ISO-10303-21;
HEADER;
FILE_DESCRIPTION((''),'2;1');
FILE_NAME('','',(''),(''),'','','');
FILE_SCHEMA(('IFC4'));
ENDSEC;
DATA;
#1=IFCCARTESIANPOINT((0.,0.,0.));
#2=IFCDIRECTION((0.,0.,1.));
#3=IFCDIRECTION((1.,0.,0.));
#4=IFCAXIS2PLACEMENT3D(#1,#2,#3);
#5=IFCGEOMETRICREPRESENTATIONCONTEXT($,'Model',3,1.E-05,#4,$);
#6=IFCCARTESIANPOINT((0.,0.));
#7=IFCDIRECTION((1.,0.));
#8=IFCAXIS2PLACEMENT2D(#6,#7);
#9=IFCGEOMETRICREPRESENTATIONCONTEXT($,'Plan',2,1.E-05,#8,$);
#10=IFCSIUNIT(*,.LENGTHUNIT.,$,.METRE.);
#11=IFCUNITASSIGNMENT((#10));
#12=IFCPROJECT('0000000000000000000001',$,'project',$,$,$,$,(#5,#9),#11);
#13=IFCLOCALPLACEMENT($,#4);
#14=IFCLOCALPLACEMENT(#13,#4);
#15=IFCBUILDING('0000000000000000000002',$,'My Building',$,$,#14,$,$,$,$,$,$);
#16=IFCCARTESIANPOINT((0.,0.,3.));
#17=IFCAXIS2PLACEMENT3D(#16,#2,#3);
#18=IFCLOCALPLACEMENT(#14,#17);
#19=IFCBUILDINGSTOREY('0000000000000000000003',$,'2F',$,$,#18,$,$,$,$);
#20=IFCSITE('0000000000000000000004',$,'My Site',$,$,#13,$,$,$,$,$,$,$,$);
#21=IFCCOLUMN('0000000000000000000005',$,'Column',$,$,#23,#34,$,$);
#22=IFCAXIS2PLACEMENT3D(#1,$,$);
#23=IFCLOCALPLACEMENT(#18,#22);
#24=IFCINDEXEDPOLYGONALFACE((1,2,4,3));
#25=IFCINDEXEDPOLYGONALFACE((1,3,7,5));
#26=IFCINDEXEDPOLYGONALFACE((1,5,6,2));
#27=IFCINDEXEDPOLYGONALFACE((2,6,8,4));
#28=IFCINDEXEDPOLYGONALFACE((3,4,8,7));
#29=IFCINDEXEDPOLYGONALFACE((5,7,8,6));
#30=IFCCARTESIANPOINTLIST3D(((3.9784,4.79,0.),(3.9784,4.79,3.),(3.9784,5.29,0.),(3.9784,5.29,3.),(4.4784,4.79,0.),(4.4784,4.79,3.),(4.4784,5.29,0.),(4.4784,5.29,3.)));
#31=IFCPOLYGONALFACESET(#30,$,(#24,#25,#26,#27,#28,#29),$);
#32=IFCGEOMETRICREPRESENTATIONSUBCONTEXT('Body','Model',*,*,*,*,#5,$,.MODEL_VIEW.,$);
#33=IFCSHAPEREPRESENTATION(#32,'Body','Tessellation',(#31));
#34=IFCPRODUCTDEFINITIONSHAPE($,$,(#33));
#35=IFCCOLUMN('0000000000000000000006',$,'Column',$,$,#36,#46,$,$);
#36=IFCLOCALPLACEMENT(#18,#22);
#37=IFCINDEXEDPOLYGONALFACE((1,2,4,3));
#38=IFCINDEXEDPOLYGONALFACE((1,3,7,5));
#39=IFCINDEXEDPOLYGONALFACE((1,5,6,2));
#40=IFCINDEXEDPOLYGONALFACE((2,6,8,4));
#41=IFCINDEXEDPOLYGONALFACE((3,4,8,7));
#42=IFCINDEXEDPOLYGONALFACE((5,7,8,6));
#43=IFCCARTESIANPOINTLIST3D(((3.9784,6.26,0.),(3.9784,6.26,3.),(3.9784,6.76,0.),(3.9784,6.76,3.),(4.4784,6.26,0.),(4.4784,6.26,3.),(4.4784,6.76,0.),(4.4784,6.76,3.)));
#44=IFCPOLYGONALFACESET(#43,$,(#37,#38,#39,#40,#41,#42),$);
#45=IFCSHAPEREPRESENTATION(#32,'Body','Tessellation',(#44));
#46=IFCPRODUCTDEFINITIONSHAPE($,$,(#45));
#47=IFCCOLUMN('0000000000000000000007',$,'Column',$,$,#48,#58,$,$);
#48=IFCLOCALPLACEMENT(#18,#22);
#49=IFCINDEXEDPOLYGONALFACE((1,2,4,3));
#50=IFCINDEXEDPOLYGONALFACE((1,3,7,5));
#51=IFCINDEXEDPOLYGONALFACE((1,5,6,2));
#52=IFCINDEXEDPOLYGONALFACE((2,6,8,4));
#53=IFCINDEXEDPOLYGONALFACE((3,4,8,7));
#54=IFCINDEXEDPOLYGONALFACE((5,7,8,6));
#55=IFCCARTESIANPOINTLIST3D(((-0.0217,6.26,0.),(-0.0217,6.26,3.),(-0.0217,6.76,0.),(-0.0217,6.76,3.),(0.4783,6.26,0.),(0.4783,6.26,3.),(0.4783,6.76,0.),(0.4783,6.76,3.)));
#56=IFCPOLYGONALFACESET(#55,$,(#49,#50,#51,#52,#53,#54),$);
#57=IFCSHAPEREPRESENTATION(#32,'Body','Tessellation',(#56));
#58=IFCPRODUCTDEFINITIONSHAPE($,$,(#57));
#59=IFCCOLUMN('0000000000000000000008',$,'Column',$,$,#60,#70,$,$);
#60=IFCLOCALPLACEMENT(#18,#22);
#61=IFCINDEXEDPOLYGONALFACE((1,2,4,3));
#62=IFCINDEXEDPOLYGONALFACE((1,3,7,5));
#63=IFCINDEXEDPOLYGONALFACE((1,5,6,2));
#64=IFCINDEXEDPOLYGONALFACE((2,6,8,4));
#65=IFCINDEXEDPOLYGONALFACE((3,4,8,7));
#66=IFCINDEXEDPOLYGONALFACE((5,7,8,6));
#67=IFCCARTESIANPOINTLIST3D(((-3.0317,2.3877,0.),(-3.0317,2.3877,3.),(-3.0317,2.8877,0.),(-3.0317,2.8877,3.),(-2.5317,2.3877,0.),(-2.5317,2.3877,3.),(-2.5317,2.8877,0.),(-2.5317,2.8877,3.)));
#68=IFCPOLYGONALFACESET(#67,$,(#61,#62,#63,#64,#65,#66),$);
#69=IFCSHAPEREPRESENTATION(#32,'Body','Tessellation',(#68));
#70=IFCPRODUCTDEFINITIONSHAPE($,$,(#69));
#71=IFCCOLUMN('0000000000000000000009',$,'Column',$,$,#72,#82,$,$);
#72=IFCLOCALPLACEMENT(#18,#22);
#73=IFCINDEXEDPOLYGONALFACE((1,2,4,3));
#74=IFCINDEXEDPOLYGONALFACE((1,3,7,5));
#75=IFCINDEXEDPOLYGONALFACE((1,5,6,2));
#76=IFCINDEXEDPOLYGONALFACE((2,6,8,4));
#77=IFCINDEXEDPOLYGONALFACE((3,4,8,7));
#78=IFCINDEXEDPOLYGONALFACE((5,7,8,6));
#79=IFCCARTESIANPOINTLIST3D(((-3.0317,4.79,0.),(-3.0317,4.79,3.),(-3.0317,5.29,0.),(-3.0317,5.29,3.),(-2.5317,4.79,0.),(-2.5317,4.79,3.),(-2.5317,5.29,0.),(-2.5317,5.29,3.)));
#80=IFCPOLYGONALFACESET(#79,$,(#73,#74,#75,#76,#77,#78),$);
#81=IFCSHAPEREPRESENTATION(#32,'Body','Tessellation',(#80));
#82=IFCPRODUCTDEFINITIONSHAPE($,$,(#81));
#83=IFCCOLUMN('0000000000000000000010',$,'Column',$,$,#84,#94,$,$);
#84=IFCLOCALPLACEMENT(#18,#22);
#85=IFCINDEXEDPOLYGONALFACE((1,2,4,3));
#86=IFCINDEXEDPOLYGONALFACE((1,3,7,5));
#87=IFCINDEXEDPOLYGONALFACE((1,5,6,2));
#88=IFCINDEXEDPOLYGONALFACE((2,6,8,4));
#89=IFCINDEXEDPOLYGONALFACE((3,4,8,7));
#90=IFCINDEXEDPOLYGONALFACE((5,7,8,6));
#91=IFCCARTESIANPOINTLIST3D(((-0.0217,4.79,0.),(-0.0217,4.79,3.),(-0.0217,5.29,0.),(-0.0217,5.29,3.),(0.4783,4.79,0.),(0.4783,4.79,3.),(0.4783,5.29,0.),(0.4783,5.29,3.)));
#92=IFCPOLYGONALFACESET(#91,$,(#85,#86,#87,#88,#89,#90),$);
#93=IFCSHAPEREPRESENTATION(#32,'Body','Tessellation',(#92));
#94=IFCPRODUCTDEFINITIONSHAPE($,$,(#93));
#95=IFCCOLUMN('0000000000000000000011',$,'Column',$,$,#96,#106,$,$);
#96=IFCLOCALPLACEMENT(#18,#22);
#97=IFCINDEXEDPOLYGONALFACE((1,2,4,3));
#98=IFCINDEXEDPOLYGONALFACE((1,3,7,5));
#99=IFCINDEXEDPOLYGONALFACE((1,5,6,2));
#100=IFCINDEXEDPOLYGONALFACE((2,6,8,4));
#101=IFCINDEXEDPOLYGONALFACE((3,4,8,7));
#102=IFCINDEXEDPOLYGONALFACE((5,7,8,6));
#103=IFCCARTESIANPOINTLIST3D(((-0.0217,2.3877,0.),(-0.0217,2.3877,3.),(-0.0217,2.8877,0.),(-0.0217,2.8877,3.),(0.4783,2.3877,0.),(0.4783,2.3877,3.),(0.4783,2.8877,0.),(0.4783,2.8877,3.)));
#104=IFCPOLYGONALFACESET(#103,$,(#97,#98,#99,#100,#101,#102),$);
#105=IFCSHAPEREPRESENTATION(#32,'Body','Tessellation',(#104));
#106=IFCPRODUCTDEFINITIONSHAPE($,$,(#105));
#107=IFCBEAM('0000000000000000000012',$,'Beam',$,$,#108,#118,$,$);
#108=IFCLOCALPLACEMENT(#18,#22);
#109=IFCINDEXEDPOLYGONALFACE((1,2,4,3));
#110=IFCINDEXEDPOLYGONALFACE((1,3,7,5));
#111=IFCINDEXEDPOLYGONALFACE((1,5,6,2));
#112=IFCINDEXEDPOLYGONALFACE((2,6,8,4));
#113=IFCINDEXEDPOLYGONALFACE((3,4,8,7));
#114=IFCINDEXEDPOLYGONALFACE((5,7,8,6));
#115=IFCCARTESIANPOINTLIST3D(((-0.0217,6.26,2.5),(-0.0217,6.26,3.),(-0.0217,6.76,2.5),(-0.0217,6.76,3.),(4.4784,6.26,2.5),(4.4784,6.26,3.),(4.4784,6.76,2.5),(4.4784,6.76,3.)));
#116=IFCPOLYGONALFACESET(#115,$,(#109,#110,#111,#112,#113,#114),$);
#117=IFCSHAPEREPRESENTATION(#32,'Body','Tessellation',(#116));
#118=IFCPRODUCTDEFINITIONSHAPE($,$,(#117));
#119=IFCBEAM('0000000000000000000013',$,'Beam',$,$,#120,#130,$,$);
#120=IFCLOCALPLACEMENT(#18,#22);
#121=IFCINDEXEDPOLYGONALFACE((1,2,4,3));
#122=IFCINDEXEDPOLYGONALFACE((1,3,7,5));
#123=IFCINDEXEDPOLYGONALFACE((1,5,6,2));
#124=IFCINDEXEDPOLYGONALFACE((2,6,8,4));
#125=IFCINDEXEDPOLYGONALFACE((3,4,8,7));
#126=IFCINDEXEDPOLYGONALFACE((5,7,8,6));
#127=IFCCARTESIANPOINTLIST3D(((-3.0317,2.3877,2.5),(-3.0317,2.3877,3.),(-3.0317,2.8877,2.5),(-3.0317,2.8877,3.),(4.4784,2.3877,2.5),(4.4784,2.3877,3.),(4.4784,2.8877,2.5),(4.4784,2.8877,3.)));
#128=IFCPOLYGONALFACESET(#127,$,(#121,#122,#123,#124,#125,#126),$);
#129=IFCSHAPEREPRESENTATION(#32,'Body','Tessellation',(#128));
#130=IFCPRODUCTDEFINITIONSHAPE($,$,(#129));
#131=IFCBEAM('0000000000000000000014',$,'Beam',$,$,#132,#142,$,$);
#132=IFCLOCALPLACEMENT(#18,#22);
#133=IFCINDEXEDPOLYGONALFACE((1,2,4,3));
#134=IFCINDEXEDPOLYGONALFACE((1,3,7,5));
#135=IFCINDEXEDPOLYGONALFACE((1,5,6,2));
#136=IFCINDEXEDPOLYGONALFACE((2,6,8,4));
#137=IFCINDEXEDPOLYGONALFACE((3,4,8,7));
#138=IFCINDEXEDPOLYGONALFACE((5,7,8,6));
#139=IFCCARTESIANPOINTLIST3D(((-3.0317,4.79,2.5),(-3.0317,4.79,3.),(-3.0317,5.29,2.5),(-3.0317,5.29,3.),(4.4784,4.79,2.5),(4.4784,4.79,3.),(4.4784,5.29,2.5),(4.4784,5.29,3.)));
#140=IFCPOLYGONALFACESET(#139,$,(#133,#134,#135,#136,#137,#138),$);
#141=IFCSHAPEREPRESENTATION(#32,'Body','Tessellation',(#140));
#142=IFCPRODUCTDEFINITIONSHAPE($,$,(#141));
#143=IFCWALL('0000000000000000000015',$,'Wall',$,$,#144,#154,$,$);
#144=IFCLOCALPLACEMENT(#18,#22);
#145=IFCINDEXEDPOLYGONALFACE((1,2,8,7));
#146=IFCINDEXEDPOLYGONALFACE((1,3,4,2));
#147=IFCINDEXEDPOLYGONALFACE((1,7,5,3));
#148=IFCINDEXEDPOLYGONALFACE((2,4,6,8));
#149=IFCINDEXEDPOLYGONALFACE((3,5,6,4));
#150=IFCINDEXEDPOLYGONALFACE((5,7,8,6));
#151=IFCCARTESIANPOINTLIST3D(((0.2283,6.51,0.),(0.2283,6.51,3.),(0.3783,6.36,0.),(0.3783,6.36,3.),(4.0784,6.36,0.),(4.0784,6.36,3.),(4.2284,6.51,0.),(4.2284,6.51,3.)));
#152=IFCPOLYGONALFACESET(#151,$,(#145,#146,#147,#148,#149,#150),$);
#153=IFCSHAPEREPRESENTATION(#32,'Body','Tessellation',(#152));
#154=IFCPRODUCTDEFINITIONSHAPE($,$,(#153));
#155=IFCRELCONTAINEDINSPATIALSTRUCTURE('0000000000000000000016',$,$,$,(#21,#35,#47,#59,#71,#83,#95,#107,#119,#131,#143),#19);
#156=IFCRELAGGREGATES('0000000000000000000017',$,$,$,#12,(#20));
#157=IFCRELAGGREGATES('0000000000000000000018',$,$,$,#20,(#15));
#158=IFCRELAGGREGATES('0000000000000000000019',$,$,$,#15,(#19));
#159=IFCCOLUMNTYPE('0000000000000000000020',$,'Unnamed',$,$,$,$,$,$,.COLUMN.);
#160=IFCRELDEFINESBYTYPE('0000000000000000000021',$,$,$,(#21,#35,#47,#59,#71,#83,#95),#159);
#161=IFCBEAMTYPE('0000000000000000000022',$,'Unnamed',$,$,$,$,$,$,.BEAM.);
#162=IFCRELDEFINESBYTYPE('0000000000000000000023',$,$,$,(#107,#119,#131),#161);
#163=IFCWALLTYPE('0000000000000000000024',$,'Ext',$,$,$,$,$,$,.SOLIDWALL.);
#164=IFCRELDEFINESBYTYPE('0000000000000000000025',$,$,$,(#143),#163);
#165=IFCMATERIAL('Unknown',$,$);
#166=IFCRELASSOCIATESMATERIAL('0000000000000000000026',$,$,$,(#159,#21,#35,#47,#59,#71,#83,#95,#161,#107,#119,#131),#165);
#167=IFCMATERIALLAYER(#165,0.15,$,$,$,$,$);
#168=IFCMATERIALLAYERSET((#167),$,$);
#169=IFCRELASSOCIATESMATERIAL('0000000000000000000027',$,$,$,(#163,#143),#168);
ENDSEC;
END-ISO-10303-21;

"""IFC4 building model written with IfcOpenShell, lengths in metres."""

from ifc_helpers import new_model, si_unit, frame, origin_with_axes, origin_2d_with_axis, place, context, subcontext, project, spatial, line, indexed_curve, outline, extrude, material, layer, layer_set, layer_usage, material_profile, profile_set, profile_usage, type_object, element, save


model = new_model("IFC4")

# Units and contexts
model_context = context("Model", 3, precision=1e-05, world=origin_with_axes())
plan_context = context("Plan", 2, precision=1e-05, world=origin_2d_with_axis())
body_context_1 = subcontext(model_context, "Body", "Model", "MODEL_VIEW")
ifc_project = project(units=[si_unit("LENGTHUNIT", "METRE")], contexts=[model_context, plan_context])

# Site, building, storey
site_placement = place(None, origin_with_axes())
site = spatial("IfcSite", under=ifc_project, at=site_placement, Name="My Site")
building_placement = place(site_placement, origin_with_axes())
building = spatial("IfcBuilding", under=site, at=building_placement, Name="My Building")
storey_placement = place(building_placement, frame((0.0, 0.0, 3.0), z_axis=(0.0, 0.0, 1.0), x_axis=(1.0, 0.0, 0.0)))
storey = spatial("IfcBuildingStorey", under=building, at=storey_placement, Name="2F")

# Columns
ifc_material = material(Name="Unknown")
ifc_material_profile_1 = material_profile(ifc_material, outline(indexed_curve([(-0.25, -0.25), (0.25, -0.25), (0.25, 0.25), (-0.25, 0.25), (-0.25, -0.25)])))
ifc_profile_set_1 = profile_set([ifc_material_profile_1])
ifc_profile_usage_1 = profile_usage(ifc_profile_set_1, cardinal=3)
column_type = type_object("IfcColumnType", Name="Unnamed", PredefinedType="COLUMN", material=ifc_profile_set_1)
column_1_placement = place(storey_placement, frame((3.9784, 4.79, 0.0), z_axis=(0.0, 0.0, 1.0), x_axis=(1.0, 0.0, 0.0)))
element("IfcColumn", 1, at=column_1_placement, inside=storey, type_object=column_type, material=ifc_profile_usage_1, Name="Column", context=body_context_1, shape_type="SweptSolid", body=[
    extrude(outline(indexed_curve([(-0.25, -0.25), (0.25, -0.25), (0.25, 0.25), (-0.25, 0.25), (-0.25, -0.25)])), frame((0.25, 0.25, 0.0), z_axis=(0.0, 0.0, 1.0), x_axis=(1.0, 0.0, 0.0)), (0.0, 0.0, 1.0), 3.0),
])
ifc_profile_usage_2 = profile_usage(ifc_profile_set_1, cardinal=3)
column_2_placement = place(storey_placement, frame((3.9784, 6.26, 0.0), z_axis=(0.0, 0.0, 1.0), x_axis=(1.0, 0.0, 0.0)))
element("IfcColumn", 2, at=column_2_placement, inside=storey, type_object=column_type, material=ifc_profile_usage_2, Name="Column", context=body_context_1, shape_type="SweptSolid", body=[
    extrude(outline(indexed_curve([(-0.25, -0.25), (0.25, -0.25), (0.25, 0.25), (-0.25, 0.25), (-0.25, -0.25)])), frame((0.25, 0.25, 0.0), z_axis=(0.0, 0.0, 1.0), x_axis=(1.0, 0.0, 0.0)), (0.0, 0.0, 1.0), 3.0),
])
ifc_profile_usage_3 = profile_usage(ifc_profile_set_1, cardinal=3)
column_3_placement = place(storey_placement, frame((-0.0217, 6.26, 0.0), z_axis=(0.0, 0.0, 1.0), x_axis=(1.0, 0.0, 0.0)))
element("IfcColumn", 3, at=column_3_placement, inside=storey, type_object=column_type, material=ifc_profile_usage_3, Name="Column", context=body_context_1, shape_type="SweptSolid", body=[
    extrude(outline(indexed_curve([(-0.25, -0.25), (0.25, -0.25), (0.25, 0.25), (-0.25, 0.25), (-0.25, -0.25)])), frame((0.25, 0.25, 0.0), z_axis=(0.0, 0.0, 1.0), x_axis=(1.0, 0.0, 0.0)), (0.0, 0.0, 1.0), 3.0),
])
ifc_profile_usage_4 = profile_usage(ifc_profile_set_1, cardinal=3)
column_4_placement = place(storey_placement, frame((-3.0317, 2.3877, 0.0), z_axis=(0.0, 0.0, 1.0), x_axis=(1.0, 0.0, 0.0)))
element("IfcColumn", 4, at=column_4_placement, inside=storey, type_object=column_type, material=ifc_profile_usage_4, Name="Column", context=body_context_1, shape_type="SweptSolid", body=[
    extrude(outline(indexed_curve([(-0.25, -0.25), (0.25, -0.25), (0.25, 0.25), (-0.25, 0.25), (-0.25, -0.25)])), frame((0.25, 0.25, 0.0), z_axis=(0.0, 0.0, 1.0), x_axis=(1.0, 0.0, 0.0)), (0.0, 0.0, 1.0), 3.0),
])
ifc_profile_usage_5 = profile_usage(ifc_profile_set_1, cardinal=3)
column_5_placement = place(storey_placement, frame((-3.0317, 4.79, 0.0), z_axis=(0.0, 0.0, 1.0), x_axis=(1.0, 0.0, 0.0)))
element("IfcColumn", 5, at=column_5_placement, inside=storey, type_object=column_type, material=ifc_profile_usage_5, Name="Column", context=body_context_1, shape_type="SweptSolid", body=[
    extrude(outline(indexed_curve([(-0.25, -0.25), (0.25, -0.25), (0.25, 0.25), (-0.25, 0.25), (-0.25, -0.25)])), frame((0.25, 0.25, 0.0), z_axis=(0.0, 0.0, 1.0), x_axis=(1.0, 0.0, 0.0)), (0.0, 0.0, 1.0), 3.0),
])
ifc_profile_usage_6 = profile_usage(ifc_profile_set_1, cardinal=3)
column_6_placement = place(storey_placement, frame((-0.0217, 4.79, 0.0), z_axis=(0.0, 0.0, 1.0), x_axis=(1.0, 0.0, 0.0)))
element("IfcColumn", 6, at=column_6_placement, inside=storey, type_object=column_type, material=ifc_profile_usage_6, Name="Column", context=body_context_1, shape_type="SweptSolid", body=[
    extrude(outline(indexed_curve([(-0.25, -0.25), (0.25, -0.25), (0.25, 0.25), (-0.25, 0.25), (-0.25, -0.25)])), frame((0.25, 0.25, 0.0), z_axis=(0.0, 0.0, 1.0), x_axis=(1.0, 0.0, 0.0)), (0.0, 0.0, 1.0), 3.0),
])
ifc_profile_usage_7 = profile_usage(ifc_profile_set_1, cardinal=3)
column_7_placement = place(storey_placement, frame((-0.0217, 2.3877, 0.0), z_axis=(0.0, 0.0, 1.0), x_axis=(1.0, 0.0, 0.0)))
element("IfcColumn", 7, at=column_7_placement, inside=storey, type_object=column_type, material=ifc_profile_usage_7, Name="Column", context=body_context_1, shape_type="SweptSolid", body=[
    extrude(outline(indexed_curve([(-0.25, -0.25), (0.25, -0.25), (0.25, 0.25), (-0.25, 0.25), (-0.25, -0.25)])), frame((0.25, 0.25, 0.0), z_axis=(0.0, 0.0, 1.0), x_axis=(1.0, 0.0, 0.0)), (0.0, 0.0, 1.0), 3.0),
])

# Beams
ifc_material_profile_2 = material_profile(ifc_material, outline(indexed_curve([(-0.25, -0.25), (0.25, -0.25), (0.25, 0.25), (-0.25, 0.25), (-0.25, -0.25)])))
ifc_profile_set_2 = profile_set([ifc_material_profile_2])
ifc_profile_usage_8 = profile_usage(ifc_profile_set_2, cardinal=7)
beam_type = type_object("IfcBeamType", Name="Unnamed", PredefinedType="BEAM", material=ifc_profile_set_2)
beam_1_placement = place(storey_placement, frame((4.4784, 6.26, 3.0), z_axis=(-1.0, 0.0, 0.0), x_axis=(0.0, -1.0, 0.0)))
element("IfcBeam", 8, at=beam_1_placement, inside=storey, type_object=beam_type, material=ifc_profile_usage_8, Name="Beam", context=body_context_1, shape_type="SweptSolid", body=[
    extrude(outline(indexed_curve([(-0.25, -0.25), (0.25, -0.25), (0.25, 0.25), (-0.25, 0.25), (-0.25, -0.25)])), frame((-0.25, -0.25, 0.0), z_axis=(0.0, 0.0, 1.0), x_axis=(1.0, 0.0, 0.0)), (0.0, 0.0, 1.0), 4.5),
])
ifc_profile_usage_9 = profile_usage(ifc_profile_set_2, cardinal=7)
beam_2_placement = place(storey_placement, frame((4.4784, 2.3877, 3.0), z_axis=(-1.0, 0.0, 0.0), x_axis=(0.0, -1.0, 0.0)))
element("IfcBeam", 9, at=beam_2_placement, inside=storey, type_object=beam_type, material=ifc_profile_usage_9, Name="Beam", context=body_context_1, shape_type="SweptSolid", body=[
    extrude(outline(indexed_curve([(-0.25, -0.25), (0.25, -0.25), (0.25, 0.25), (-0.25, 0.25), (-0.25, -0.25)])), frame((-0.25, -0.25, 0.0), z_axis=(0.0, 0.0, 1.0), x_axis=(1.0, 0.0, 0.0)), (0.0, 0.0, 1.0), 7.51),
])
ifc_profile_usage_10 = profile_usage(ifc_profile_set_2, cardinal=7)
beam_3_placement = place(storey_placement, frame((4.4784, 4.79, 3.0), z_axis=(-1.0, 0.0, 0.0), x_axis=(0.0, -1.0, 0.0)))
element("IfcBeam", 10, at=beam_3_placement, inside=storey, type_object=beam_type, material=ifc_profile_usage_10, Name="Beam", context=body_context_1, shape_type="SweptSolid", body=[
    extrude(outline(indexed_curve([(-0.25, -0.25), (0.25, -0.25), (0.25, 0.25), (-0.25, 0.25), (-0.25, -0.25)])), frame((-0.25, -0.25, 0.0), z_axis=(0.0, 0.0, 1.0), x_axis=(1.0, 0.0, 0.0)), (0.0, 0.0, 1.0), 7.51),
])

# Wall
ifc_layer_1 = layer(ifc_material, 0.15)
ifc_layer_set_1 = layer_set([ifc_layer_1])
ifc_layer_usage_1 = layer_usage(ifc_layer_set_1, "AXIS2", "POSITIVE", 0.0)
wall_type_1 = type_object("IfcWallType", Name="Ext", PredefinedType="SOLIDWALL", material=ifc_layer_set_1)
wall_1_placement = place(storey_placement, frame((4.2284, 6.51, 0.0), z_axis=(0.0, 0.0, 1.0), x_axis=(-1.0, 0.0, 0.0)))
element("IfcWall", 11, at=wall_1_placement, inside=storey, type_object=wall_type_1, material=ifc_layer_usage_1, Name="Wall", context=body_context_1, shape_type="SweptSolid", body=[
    extrude(outline(indexed_curve([(0.0, 0.0), (0.15, 0.15), (3.85, 0.15), (4.0, 0.0)], segments=[line(1, 2, 3, 4, 1)])), origin_with_axes(), (0.0, 0.0, 1.0), 3.0),
])

save(model, "model.ifc")
